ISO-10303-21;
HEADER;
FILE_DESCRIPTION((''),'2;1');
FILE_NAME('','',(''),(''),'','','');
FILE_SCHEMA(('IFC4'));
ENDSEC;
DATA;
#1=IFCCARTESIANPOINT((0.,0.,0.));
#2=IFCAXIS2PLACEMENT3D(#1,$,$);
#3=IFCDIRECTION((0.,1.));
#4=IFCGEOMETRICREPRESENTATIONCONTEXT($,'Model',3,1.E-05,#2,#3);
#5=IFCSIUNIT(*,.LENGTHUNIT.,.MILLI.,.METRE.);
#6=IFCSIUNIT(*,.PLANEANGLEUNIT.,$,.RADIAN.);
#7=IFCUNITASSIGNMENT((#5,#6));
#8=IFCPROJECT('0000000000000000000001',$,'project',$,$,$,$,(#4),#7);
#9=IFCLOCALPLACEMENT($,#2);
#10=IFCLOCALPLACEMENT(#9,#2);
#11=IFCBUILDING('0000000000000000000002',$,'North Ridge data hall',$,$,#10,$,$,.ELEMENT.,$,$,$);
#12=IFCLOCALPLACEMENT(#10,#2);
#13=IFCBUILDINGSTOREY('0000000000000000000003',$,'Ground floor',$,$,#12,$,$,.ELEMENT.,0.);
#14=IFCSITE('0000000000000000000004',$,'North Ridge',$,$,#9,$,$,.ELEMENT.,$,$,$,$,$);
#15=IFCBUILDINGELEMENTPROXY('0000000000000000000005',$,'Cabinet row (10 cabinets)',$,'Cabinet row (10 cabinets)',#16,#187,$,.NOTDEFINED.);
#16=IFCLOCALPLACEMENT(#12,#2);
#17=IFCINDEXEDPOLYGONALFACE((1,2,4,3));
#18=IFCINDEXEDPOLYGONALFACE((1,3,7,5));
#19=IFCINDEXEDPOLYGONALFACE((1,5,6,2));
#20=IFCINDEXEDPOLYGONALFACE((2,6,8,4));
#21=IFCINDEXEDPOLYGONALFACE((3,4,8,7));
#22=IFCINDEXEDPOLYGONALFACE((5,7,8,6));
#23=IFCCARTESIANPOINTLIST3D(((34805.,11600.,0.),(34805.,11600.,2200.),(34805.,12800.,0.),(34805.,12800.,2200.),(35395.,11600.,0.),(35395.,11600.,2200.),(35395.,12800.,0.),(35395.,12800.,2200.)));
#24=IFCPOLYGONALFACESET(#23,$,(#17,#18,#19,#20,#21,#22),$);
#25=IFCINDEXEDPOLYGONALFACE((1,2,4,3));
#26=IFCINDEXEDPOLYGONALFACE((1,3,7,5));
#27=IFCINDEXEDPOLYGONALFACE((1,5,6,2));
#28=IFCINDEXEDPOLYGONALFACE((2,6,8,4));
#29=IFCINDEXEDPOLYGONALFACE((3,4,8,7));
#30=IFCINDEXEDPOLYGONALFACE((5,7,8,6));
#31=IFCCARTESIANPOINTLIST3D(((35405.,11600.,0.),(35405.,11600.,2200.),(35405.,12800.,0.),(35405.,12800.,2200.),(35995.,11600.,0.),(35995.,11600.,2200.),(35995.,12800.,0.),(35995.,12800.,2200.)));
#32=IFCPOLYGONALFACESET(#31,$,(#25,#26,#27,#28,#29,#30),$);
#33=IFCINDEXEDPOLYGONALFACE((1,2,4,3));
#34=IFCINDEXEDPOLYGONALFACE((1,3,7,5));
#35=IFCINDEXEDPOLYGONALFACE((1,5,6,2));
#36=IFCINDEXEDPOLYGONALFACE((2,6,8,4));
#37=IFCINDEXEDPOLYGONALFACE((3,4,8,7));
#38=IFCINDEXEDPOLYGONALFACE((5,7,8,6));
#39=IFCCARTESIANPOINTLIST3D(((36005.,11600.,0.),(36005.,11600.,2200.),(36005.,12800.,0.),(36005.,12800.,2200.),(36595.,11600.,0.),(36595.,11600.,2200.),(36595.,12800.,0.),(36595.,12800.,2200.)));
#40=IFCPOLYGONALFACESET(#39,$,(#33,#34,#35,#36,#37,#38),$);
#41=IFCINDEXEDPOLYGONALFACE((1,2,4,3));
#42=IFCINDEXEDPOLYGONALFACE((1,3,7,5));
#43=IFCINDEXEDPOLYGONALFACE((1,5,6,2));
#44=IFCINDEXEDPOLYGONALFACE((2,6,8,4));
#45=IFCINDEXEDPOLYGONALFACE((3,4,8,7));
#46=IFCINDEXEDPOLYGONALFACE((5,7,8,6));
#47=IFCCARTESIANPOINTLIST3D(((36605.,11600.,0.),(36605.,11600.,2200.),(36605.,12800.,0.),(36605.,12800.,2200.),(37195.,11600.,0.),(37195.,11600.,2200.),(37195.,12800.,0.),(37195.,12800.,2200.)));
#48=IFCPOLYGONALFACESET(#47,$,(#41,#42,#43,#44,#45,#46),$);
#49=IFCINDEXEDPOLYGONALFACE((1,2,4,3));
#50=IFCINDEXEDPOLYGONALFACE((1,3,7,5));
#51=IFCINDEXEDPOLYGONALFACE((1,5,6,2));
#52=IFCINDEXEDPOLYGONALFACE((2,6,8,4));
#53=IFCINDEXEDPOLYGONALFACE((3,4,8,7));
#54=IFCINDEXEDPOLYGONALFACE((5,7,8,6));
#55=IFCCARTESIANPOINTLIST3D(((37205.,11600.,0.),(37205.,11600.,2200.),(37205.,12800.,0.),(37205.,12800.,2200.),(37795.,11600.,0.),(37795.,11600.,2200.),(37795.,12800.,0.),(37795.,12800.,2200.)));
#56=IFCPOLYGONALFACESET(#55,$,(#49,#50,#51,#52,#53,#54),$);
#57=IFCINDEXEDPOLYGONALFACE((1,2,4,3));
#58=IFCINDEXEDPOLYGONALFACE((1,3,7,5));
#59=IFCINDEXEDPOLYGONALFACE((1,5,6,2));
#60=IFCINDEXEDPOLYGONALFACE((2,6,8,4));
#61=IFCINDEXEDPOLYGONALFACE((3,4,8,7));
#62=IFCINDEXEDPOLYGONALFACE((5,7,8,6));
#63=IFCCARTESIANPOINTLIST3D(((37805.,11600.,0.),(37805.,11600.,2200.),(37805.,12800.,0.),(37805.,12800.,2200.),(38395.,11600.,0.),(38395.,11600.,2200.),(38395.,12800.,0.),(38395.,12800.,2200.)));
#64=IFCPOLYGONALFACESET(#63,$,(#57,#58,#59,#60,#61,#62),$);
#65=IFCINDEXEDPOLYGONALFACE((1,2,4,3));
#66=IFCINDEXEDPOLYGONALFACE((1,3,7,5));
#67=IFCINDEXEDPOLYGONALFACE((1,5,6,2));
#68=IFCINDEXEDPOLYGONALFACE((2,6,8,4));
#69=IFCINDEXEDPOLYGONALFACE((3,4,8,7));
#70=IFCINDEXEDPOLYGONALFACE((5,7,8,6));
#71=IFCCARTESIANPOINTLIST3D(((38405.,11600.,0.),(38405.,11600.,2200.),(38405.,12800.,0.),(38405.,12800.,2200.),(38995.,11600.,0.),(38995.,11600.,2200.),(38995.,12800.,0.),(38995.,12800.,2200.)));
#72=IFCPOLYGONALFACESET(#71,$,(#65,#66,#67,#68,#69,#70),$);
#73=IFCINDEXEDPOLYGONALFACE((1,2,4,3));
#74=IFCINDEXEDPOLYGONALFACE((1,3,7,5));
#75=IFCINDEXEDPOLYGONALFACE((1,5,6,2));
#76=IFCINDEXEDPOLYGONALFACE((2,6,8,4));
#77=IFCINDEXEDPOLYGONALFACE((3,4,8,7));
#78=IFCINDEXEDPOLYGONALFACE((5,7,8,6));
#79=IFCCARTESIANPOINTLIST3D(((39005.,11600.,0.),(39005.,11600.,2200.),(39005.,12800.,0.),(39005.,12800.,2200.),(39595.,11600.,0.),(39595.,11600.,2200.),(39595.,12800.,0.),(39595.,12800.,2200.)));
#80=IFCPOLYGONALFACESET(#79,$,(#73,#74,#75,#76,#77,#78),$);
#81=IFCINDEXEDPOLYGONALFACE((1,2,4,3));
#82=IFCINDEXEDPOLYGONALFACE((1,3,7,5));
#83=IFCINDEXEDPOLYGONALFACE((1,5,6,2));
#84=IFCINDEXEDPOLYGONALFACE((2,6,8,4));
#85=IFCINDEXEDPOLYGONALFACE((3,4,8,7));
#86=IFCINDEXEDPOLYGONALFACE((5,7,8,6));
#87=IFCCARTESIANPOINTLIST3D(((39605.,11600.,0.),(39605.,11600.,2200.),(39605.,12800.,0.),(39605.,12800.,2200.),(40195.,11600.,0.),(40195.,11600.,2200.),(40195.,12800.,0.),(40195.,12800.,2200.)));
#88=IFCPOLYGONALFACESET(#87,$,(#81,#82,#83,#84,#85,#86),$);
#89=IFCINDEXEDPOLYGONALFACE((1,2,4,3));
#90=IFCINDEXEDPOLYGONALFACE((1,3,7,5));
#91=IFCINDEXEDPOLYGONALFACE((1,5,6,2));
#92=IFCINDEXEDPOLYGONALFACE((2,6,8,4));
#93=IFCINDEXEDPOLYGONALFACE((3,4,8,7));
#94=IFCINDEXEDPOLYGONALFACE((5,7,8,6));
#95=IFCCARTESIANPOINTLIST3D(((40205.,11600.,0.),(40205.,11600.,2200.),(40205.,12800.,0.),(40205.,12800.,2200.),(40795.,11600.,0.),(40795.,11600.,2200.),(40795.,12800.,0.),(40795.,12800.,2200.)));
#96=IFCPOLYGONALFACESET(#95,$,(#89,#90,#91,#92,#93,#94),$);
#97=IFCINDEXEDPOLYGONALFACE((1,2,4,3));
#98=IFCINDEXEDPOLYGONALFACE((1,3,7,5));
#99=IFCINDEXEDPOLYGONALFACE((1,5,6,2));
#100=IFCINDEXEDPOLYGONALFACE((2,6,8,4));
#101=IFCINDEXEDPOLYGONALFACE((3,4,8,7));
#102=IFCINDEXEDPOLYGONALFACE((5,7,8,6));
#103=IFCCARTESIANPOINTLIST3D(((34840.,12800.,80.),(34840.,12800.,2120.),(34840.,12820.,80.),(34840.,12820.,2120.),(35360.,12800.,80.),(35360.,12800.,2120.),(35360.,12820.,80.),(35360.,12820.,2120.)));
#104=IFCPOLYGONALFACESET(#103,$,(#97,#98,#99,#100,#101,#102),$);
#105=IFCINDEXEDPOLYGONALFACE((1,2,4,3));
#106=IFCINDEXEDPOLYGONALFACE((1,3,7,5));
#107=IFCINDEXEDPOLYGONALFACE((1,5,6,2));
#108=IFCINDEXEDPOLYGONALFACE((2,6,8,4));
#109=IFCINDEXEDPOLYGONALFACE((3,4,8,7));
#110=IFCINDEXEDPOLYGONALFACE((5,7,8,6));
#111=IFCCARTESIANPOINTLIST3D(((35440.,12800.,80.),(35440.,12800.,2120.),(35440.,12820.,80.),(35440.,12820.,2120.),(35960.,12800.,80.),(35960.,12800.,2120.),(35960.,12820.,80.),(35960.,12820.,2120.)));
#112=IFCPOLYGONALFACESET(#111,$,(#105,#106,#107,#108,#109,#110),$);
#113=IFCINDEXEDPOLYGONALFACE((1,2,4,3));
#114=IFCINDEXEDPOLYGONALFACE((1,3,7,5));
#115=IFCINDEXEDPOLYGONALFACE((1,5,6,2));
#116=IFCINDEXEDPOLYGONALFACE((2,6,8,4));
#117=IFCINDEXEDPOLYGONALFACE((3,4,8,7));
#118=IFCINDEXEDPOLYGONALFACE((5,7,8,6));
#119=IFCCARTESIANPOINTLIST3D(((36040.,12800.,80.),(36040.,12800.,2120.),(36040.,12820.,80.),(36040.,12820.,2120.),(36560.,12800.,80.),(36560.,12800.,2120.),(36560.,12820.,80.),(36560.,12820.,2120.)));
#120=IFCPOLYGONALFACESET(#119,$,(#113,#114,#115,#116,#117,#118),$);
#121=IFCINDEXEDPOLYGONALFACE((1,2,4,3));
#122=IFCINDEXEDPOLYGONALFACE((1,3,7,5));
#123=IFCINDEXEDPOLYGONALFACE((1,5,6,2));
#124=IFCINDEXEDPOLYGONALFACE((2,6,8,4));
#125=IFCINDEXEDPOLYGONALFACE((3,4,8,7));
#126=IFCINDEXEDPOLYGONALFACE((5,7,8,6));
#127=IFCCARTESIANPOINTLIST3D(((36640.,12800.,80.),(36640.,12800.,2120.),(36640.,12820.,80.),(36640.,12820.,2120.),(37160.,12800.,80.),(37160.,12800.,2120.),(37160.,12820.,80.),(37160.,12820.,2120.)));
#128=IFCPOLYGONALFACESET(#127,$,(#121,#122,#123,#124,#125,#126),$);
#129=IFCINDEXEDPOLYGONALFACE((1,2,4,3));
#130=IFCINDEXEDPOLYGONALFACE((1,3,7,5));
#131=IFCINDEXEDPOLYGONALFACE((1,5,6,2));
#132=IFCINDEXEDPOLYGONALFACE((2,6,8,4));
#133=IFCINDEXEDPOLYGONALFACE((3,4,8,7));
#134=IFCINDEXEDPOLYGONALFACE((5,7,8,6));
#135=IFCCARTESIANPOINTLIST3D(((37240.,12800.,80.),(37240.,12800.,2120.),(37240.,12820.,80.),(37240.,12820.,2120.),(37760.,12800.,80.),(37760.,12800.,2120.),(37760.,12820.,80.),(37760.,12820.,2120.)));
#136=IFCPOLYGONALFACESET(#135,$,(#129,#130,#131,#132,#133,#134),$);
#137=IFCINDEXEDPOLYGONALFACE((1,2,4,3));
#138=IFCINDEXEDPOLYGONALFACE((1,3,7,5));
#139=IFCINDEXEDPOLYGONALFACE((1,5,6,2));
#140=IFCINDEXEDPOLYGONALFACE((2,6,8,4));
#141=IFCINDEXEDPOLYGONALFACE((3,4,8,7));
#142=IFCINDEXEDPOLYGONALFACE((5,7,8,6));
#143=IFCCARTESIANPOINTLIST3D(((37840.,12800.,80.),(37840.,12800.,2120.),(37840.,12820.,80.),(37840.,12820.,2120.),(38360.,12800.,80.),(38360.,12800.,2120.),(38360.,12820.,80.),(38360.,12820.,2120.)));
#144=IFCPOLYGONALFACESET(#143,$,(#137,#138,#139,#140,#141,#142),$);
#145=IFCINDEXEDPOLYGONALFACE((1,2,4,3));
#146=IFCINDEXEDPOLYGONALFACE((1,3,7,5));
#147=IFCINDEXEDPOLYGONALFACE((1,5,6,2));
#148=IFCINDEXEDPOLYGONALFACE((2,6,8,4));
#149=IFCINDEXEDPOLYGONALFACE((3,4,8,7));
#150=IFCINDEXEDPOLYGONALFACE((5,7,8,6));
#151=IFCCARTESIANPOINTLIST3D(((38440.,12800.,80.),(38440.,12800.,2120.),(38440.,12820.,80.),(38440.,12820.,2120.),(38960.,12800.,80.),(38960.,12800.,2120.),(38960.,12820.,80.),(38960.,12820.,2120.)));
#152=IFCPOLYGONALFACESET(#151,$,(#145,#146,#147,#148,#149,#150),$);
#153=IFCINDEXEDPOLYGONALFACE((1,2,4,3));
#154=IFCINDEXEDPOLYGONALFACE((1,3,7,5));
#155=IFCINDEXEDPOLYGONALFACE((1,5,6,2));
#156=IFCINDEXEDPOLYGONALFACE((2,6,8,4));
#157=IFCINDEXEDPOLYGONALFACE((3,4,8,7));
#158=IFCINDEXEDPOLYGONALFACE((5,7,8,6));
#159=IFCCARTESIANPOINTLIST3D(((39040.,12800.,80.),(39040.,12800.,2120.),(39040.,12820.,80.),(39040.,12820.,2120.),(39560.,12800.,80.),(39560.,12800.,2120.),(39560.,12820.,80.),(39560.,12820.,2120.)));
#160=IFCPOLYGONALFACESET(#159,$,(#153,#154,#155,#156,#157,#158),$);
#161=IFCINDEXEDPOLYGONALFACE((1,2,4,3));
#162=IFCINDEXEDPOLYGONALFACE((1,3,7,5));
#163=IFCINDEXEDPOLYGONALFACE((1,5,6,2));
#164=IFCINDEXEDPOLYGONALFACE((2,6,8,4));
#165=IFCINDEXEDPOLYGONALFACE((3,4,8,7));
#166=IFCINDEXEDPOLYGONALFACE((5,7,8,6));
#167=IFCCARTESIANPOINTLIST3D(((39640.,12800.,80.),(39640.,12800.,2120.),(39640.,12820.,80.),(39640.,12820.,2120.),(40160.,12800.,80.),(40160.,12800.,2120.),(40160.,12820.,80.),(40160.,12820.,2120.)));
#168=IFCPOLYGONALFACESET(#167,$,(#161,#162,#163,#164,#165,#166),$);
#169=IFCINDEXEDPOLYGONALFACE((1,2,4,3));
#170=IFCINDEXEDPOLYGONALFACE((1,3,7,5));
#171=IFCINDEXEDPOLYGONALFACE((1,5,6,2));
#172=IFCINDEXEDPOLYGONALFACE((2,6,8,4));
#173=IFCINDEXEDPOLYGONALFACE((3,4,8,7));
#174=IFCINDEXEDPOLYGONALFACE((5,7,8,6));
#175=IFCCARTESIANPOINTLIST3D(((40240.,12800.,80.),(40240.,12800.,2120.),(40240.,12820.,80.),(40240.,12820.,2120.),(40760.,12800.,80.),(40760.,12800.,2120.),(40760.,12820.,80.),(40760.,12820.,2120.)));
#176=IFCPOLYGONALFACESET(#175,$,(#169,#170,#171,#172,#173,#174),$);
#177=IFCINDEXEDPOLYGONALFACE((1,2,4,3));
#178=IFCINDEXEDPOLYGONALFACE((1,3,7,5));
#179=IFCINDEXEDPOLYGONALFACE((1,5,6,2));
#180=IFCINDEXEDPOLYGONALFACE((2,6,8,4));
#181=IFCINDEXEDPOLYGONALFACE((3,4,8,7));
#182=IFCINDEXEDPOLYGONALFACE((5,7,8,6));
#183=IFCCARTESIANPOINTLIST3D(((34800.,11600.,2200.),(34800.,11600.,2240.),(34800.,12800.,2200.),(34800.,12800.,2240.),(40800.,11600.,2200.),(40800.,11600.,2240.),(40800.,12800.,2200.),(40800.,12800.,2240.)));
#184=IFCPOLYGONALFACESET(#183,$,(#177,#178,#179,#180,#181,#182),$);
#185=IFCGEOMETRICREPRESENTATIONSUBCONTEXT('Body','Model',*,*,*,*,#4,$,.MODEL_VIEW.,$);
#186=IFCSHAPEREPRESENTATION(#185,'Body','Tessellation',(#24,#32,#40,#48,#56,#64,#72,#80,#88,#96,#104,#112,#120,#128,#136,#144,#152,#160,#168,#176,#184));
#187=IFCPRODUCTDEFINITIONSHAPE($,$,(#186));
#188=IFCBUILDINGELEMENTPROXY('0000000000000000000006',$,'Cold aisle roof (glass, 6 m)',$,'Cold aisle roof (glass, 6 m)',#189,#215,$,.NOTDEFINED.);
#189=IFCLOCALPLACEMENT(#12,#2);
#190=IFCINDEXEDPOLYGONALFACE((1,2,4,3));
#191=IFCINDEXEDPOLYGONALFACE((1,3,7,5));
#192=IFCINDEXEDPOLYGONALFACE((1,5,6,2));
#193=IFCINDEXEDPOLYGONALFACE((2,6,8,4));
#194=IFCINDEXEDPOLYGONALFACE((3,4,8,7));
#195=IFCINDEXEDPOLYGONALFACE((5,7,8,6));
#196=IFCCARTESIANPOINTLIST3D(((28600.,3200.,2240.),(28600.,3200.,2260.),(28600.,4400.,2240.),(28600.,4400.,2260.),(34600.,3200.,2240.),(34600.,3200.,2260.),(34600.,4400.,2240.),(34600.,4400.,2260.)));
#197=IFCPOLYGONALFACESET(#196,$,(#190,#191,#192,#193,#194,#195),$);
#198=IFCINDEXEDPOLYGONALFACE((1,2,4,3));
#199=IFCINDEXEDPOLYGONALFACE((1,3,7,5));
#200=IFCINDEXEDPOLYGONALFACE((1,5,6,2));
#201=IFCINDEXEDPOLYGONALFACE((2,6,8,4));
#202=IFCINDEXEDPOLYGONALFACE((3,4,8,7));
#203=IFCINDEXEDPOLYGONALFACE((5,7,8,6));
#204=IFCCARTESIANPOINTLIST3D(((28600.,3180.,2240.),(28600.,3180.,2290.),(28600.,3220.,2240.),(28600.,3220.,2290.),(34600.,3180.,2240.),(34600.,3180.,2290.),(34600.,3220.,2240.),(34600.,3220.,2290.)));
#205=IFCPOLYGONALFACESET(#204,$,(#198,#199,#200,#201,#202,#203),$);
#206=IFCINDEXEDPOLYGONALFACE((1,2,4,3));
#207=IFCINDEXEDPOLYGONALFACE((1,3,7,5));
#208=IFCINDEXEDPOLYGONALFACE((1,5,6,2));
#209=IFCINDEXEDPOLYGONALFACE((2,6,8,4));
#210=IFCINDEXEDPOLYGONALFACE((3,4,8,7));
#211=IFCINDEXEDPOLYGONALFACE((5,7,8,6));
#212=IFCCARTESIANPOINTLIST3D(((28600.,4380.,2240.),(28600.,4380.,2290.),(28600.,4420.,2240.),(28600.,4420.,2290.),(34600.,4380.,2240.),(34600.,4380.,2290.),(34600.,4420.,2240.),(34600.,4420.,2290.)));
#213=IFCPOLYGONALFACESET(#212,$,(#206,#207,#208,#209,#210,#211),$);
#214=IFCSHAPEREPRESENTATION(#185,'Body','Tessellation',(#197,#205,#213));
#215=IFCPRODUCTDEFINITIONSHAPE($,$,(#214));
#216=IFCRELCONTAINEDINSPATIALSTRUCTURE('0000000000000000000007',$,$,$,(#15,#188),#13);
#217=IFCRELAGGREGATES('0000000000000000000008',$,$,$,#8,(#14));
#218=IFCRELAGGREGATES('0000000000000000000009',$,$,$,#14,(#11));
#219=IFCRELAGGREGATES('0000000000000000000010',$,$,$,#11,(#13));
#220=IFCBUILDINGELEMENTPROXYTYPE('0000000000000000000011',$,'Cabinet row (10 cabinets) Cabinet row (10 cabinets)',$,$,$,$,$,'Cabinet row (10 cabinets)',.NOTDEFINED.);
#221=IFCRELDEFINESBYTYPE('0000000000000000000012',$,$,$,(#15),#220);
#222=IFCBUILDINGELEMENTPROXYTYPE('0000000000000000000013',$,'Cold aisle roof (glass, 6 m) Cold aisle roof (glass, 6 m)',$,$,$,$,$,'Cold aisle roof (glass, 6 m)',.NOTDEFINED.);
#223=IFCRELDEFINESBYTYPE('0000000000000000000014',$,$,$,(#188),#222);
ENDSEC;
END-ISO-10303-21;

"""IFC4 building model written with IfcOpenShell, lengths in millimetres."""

from ifc_helpers import new_model, si_unit, direction, frame, origin, place, context, subcontext, project, spatial, polyline, outline, extrude, source, transform, mapped, type_object, type_shapes, element, save


model = new_model("IFC4")

# Units and contexts
model_context = context("Model", 3, precision=1e-05, world=origin(), true_north=direction((0.0, 1.0)))
body_context = subcontext(model_context, "Body", "Model", "MODEL_VIEW")
ifc_project = project(units=[si_unit("LENGTHUNIT", "METRE", prefix="MILLI"), si_unit("PLANEANGLEUNIT", "RADIAN")], contexts=[model_context])

# Site, building, storey
site_placement = place(None, origin())
site = spatial("IfcSite", under=ifc_project, at=site_placement, Name="North Ridge", CompositionType="ELEMENT")
building_placement = place(site_placement, origin())
building = spatial("IfcBuilding", under=site, at=building_placement, Name="North Ridge data hall", CompositionType="ELEMENT")
storey_placement = place(building_placement, origin())
storey = spatial("IfcBuildingStorey", under=building, at=storey_placement, Name="Ground floor", CompositionType="ELEMENT", Elevation=0.0)

# Building element proxies
building_element_proxy_type_1 = type_object("IfcBuildingElementProxyType", Name="Cabinet row (10 cabinets) Cabinet row (10 cabinets)", ElementType="Cabinet row (10 cabinets)", PredefinedType="NOTDEFINED")
shared_shape_1 = source(origin(), body_context, "Body", "SweptSolid", [
    extrude(outline(polyline([(5.0, 0.0), (595.0, 0.0), (595.0, 1200.0), (5.0, 1200.0), (5.0, 0.0)])), origin(), (0.0, 0.0, 1.0), 2200.0),
    extrude(outline(polyline([(605.0, 0.0), (1195.0, 0.0), (1195.0, 1200.0), (605.0, 1200.0), (605.0, 0.0)])), origin(), (0.0, 0.0, 1.0), 2200.0),
    extrude(outline(polyline([(1205.0, 0.0), (1795.0, 0.0), (1795.0, 1200.0), (1205.0, 1200.0), (1205.0, 0.0)])), origin(), (0.0, 0.0, 1.0), 2200.0),
    extrude(outline(polyline([(1805.0, 0.0), (2395.0, 0.0), (2395.0, 1200.0), (1805.0, 1200.0), (1805.0, 0.0)])), origin(), (0.0, 0.0, 1.0), 2200.0),
    extrude(outline(polyline([(2405.0, 0.0), (2995.0, 0.0), (2995.0, 1200.0), (2405.0, 1200.0), (2405.0, 0.0)])), origin(), (0.0, 0.0, 1.0), 2200.0),
    extrude(outline(polyline([(3005.0, 0.0), (3595.0, 0.0), (3595.0, 1200.0), (3005.0, 1200.0), (3005.0, 0.0)])), origin(), (0.0, 0.0, 1.0), 2200.0),
    extrude(outline(polyline([(3605.0, 0.0), (4195.0, 0.0), (4195.0, 1200.0), (3605.0, 1200.0), (3605.0, 0.0)])), origin(), (0.0, 0.0, 1.0), 2200.0),
    extrude(outline(polyline([(4205.0, 0.0), (4795.0, 0.0), (4795.0, 1200.0), (4205.0, 1200.0), (4205.0, 0.0)])), origin(), (0.0, 0.0, 1.0), 2200.0),
    extrude(outline(polyline([(4805.0, 0.0), (5395.0, 0.0), (5395.0, 1200.0), (4805.0, 1200.0), (4805.0, 0.0)])), origin(), (0.0, 0.0, 1.0), 2200.0),
    extrude(outline(polyline([(5405.0, 0.0), (5995.0, 0.0), (5995.0, 1200.0), (5405.0, 1200.0), (5405.0, 0.0)])), origin(), (0.0, 0.0, 1.0), 2200.0),
    extrude(outline(polyline([(40.0, 1200.0), (560.0, 1200.0), (560.0, 1220.0), (40.0, 1220.0), (40.0, 1200.0)])), frame((0.0, 0.0, 80.0)), (0.0, 0.0, 1.0), 2040.0),
    extrude(outline(polyline([(640.0, 1200.0), (1160.0, 1200.0), (1160.0, 1220.0), (640.0, 1220.0), (640.0, 1200.0)])), frame((0.0, 0.0, 80.0)), (0.0, 0.0, 1.0), 2040.0),
    extrude(outline(polyline([(1240.0, 1200.0), (1760.0, 1200.0), (1760.0, 1220.0), (1240.0, 1220.0), (1240.0, 1200.0)])), frame((0.0, 0.0, 80.0)), (0.0, 0.0, 1.0), 2040.0),
    extrude(outline(polyline([(1840.0, 1200.0), (2360.0, 1200.0), (2360.0, 1220.0), (1840.0, 1220.0), (1840.0, 1200.0)])), frame((0.0, 0.0, 80.0)), (0.0, 0.0, 1.0), 2040.0),
    extrude(outline(polyline([(2440.0, 1200.0), (2960.0, 1200.0), (2960.0, 1220.0), (2440.0, 1220.0), (2440.0, 1200.0)])), frame((0.0, 0.0, 80.0)), (0.0, 0.0, 1.0), 2040.0),
    extrude(outline(polyline([(3040.0, 1200.0), (3560.0, 1200.0), (3560.0, 1220.0), (3040.0, 1220.0), (3040.0, 1200.0)])), frame((0.0, 0.0, 80.0)), (0.0, 0.0, 1.0), 2040.0),
    extrude(outline(polyline([(3640.0, 1200.0), (4160.0, 1200.0), (4160.0, 1220.0), (3640.0, 1220.0), (3640.0, 1200.0)])), frame((0.0, 0.0, 80.0)), (0.0, 0.0, 1.0), 2040.0),
    extrude(outline(polyline([(4240.0, 1200.0), (4760.0, 1200.0), (4760.0, 1220.0), (4240.0, 1220.0), (4240.0, 1200.0)])), frame((0.0, 0.0, 80.0)), (0.0, 0.0, 1.0), 2040.0),
    extrude(outline(polyline([(4840.0, 1200.0), (5360.0, 1200.0), (5360.0, 1220.0), (4840.0, 1220.0), (4840.0, 1200.0)])), frame((0.0, 0.0, 80.0)), (0.0, 0.0, 1.0), 2040.0),
    extrude(outline(polyline([(5440.0, 1200.0), (5960.0, 1200.0), (5960.0, 1220.0), (5440.0, 1220.0), (5440.0, 1200.0)])), frame((0.0, 0.0, 80.0)), (0.0, 0.0, 1.0), 2040.0),
    extrude(outline(polyline([(0.0, 0.0), (6000.0, 0.0), (6000.0, 1200.0), (0.0, 1200.0), (0.0, 0.0)])), frame((0.0, 0.0, 2200.0)), (0.0, 0.0, 1.0), 40.0),
])
type_shapes(building_element_proxy_type_1, [shared_shape_1])
for number, where, z_axis, x_axis, name in (
    (1, (34800.0, 11600.0, 0.0), (0.0, 0.0, 1.0), (1.0, 0.0, 0.0), "Cabinet row (10 cabinets)"),
):
    element("IfcBuildingElementProxy", number, at=place(storey_placement, frame(where, z_axis=z_axis, x_axis=x_axis)), inside=storey, type_object=building_element_proxy_type_1, Name=name, ObjectType="Cabinet row (10 cabinets)", PredefinedType="NOTDEFINED", context=body_context, shape_type="MappedRepresentation", body=[
        mapped(shared_shape_1, transform((0.0, 0.0, 0.0))),
    ])
building_element_proxy_type_2 = type_object("IfcBuildingElementProxyType", Name="Cold aisle roof (glass, 6 m) Cold aisle roof (glass, 6 m)", ElementType="Cold aisle roof (glass, 6 m)", PredefinedType="NOTDEFINED")
shared_shape_2 = source(origin(), body_context, "Body", "SweptSolid", [
    extrude(outline(polyline([(0.0, 0.0), (6000.0, 0.0), (6000.0, 1200.0), (0.0, 1200.0), (0.0, 0.0)])), frame((0.0, 0.0, 2240.0)), (0.0, 0.0, 1.0), 20.0),
    extrude(outline(polyline([(0.0, -20.0), (6000.0, -20.0), (6000.0, 20.0), (0.0, 20.0), (0.0, -20.0)])), frame((0.0, 0.0, 2240.0)), (0.0, 0.0, 1.0), 50.0),
    extrude(outline(polyline([(0.0, 1180.0), (6000.0, 1180.0), (6000.0, 1220.0), (0.0, 1220.0), (0.0, 1180.0)])), frame((0.0, 0.0, 2240.0)), (0.0, 0.0, 1.0), 50.0),
])
type_shapes(building_element_proxy_type_2, [shared_shape_2])
for number, where, z_axis, x_axis, name in (
    (2, (28600.0, 3200.0, 0.0), (0.0, 0.0, 1.0), (1.0, 0.0, 0.0), "Cold aisle roof (glass, 6 m)"),
):
    element("IfcBuildingElementProxy", number, at=place(storey_placement, frame(where, z_axis=z_axis, x_axis=x_axis)), inside=storey, type_object=building_element_proxy_type_2, Name=name, ObjectType="Cold aisle roof (glass, 6 m)", PredefinedType="NOTDEFINED", context=body_context, shape_type="MappedRepresentation", body=[
        mapped(shared_shape_2, transform((0.0, 0.0, 0.0))),
    ])

save(model, "model.ifc")
